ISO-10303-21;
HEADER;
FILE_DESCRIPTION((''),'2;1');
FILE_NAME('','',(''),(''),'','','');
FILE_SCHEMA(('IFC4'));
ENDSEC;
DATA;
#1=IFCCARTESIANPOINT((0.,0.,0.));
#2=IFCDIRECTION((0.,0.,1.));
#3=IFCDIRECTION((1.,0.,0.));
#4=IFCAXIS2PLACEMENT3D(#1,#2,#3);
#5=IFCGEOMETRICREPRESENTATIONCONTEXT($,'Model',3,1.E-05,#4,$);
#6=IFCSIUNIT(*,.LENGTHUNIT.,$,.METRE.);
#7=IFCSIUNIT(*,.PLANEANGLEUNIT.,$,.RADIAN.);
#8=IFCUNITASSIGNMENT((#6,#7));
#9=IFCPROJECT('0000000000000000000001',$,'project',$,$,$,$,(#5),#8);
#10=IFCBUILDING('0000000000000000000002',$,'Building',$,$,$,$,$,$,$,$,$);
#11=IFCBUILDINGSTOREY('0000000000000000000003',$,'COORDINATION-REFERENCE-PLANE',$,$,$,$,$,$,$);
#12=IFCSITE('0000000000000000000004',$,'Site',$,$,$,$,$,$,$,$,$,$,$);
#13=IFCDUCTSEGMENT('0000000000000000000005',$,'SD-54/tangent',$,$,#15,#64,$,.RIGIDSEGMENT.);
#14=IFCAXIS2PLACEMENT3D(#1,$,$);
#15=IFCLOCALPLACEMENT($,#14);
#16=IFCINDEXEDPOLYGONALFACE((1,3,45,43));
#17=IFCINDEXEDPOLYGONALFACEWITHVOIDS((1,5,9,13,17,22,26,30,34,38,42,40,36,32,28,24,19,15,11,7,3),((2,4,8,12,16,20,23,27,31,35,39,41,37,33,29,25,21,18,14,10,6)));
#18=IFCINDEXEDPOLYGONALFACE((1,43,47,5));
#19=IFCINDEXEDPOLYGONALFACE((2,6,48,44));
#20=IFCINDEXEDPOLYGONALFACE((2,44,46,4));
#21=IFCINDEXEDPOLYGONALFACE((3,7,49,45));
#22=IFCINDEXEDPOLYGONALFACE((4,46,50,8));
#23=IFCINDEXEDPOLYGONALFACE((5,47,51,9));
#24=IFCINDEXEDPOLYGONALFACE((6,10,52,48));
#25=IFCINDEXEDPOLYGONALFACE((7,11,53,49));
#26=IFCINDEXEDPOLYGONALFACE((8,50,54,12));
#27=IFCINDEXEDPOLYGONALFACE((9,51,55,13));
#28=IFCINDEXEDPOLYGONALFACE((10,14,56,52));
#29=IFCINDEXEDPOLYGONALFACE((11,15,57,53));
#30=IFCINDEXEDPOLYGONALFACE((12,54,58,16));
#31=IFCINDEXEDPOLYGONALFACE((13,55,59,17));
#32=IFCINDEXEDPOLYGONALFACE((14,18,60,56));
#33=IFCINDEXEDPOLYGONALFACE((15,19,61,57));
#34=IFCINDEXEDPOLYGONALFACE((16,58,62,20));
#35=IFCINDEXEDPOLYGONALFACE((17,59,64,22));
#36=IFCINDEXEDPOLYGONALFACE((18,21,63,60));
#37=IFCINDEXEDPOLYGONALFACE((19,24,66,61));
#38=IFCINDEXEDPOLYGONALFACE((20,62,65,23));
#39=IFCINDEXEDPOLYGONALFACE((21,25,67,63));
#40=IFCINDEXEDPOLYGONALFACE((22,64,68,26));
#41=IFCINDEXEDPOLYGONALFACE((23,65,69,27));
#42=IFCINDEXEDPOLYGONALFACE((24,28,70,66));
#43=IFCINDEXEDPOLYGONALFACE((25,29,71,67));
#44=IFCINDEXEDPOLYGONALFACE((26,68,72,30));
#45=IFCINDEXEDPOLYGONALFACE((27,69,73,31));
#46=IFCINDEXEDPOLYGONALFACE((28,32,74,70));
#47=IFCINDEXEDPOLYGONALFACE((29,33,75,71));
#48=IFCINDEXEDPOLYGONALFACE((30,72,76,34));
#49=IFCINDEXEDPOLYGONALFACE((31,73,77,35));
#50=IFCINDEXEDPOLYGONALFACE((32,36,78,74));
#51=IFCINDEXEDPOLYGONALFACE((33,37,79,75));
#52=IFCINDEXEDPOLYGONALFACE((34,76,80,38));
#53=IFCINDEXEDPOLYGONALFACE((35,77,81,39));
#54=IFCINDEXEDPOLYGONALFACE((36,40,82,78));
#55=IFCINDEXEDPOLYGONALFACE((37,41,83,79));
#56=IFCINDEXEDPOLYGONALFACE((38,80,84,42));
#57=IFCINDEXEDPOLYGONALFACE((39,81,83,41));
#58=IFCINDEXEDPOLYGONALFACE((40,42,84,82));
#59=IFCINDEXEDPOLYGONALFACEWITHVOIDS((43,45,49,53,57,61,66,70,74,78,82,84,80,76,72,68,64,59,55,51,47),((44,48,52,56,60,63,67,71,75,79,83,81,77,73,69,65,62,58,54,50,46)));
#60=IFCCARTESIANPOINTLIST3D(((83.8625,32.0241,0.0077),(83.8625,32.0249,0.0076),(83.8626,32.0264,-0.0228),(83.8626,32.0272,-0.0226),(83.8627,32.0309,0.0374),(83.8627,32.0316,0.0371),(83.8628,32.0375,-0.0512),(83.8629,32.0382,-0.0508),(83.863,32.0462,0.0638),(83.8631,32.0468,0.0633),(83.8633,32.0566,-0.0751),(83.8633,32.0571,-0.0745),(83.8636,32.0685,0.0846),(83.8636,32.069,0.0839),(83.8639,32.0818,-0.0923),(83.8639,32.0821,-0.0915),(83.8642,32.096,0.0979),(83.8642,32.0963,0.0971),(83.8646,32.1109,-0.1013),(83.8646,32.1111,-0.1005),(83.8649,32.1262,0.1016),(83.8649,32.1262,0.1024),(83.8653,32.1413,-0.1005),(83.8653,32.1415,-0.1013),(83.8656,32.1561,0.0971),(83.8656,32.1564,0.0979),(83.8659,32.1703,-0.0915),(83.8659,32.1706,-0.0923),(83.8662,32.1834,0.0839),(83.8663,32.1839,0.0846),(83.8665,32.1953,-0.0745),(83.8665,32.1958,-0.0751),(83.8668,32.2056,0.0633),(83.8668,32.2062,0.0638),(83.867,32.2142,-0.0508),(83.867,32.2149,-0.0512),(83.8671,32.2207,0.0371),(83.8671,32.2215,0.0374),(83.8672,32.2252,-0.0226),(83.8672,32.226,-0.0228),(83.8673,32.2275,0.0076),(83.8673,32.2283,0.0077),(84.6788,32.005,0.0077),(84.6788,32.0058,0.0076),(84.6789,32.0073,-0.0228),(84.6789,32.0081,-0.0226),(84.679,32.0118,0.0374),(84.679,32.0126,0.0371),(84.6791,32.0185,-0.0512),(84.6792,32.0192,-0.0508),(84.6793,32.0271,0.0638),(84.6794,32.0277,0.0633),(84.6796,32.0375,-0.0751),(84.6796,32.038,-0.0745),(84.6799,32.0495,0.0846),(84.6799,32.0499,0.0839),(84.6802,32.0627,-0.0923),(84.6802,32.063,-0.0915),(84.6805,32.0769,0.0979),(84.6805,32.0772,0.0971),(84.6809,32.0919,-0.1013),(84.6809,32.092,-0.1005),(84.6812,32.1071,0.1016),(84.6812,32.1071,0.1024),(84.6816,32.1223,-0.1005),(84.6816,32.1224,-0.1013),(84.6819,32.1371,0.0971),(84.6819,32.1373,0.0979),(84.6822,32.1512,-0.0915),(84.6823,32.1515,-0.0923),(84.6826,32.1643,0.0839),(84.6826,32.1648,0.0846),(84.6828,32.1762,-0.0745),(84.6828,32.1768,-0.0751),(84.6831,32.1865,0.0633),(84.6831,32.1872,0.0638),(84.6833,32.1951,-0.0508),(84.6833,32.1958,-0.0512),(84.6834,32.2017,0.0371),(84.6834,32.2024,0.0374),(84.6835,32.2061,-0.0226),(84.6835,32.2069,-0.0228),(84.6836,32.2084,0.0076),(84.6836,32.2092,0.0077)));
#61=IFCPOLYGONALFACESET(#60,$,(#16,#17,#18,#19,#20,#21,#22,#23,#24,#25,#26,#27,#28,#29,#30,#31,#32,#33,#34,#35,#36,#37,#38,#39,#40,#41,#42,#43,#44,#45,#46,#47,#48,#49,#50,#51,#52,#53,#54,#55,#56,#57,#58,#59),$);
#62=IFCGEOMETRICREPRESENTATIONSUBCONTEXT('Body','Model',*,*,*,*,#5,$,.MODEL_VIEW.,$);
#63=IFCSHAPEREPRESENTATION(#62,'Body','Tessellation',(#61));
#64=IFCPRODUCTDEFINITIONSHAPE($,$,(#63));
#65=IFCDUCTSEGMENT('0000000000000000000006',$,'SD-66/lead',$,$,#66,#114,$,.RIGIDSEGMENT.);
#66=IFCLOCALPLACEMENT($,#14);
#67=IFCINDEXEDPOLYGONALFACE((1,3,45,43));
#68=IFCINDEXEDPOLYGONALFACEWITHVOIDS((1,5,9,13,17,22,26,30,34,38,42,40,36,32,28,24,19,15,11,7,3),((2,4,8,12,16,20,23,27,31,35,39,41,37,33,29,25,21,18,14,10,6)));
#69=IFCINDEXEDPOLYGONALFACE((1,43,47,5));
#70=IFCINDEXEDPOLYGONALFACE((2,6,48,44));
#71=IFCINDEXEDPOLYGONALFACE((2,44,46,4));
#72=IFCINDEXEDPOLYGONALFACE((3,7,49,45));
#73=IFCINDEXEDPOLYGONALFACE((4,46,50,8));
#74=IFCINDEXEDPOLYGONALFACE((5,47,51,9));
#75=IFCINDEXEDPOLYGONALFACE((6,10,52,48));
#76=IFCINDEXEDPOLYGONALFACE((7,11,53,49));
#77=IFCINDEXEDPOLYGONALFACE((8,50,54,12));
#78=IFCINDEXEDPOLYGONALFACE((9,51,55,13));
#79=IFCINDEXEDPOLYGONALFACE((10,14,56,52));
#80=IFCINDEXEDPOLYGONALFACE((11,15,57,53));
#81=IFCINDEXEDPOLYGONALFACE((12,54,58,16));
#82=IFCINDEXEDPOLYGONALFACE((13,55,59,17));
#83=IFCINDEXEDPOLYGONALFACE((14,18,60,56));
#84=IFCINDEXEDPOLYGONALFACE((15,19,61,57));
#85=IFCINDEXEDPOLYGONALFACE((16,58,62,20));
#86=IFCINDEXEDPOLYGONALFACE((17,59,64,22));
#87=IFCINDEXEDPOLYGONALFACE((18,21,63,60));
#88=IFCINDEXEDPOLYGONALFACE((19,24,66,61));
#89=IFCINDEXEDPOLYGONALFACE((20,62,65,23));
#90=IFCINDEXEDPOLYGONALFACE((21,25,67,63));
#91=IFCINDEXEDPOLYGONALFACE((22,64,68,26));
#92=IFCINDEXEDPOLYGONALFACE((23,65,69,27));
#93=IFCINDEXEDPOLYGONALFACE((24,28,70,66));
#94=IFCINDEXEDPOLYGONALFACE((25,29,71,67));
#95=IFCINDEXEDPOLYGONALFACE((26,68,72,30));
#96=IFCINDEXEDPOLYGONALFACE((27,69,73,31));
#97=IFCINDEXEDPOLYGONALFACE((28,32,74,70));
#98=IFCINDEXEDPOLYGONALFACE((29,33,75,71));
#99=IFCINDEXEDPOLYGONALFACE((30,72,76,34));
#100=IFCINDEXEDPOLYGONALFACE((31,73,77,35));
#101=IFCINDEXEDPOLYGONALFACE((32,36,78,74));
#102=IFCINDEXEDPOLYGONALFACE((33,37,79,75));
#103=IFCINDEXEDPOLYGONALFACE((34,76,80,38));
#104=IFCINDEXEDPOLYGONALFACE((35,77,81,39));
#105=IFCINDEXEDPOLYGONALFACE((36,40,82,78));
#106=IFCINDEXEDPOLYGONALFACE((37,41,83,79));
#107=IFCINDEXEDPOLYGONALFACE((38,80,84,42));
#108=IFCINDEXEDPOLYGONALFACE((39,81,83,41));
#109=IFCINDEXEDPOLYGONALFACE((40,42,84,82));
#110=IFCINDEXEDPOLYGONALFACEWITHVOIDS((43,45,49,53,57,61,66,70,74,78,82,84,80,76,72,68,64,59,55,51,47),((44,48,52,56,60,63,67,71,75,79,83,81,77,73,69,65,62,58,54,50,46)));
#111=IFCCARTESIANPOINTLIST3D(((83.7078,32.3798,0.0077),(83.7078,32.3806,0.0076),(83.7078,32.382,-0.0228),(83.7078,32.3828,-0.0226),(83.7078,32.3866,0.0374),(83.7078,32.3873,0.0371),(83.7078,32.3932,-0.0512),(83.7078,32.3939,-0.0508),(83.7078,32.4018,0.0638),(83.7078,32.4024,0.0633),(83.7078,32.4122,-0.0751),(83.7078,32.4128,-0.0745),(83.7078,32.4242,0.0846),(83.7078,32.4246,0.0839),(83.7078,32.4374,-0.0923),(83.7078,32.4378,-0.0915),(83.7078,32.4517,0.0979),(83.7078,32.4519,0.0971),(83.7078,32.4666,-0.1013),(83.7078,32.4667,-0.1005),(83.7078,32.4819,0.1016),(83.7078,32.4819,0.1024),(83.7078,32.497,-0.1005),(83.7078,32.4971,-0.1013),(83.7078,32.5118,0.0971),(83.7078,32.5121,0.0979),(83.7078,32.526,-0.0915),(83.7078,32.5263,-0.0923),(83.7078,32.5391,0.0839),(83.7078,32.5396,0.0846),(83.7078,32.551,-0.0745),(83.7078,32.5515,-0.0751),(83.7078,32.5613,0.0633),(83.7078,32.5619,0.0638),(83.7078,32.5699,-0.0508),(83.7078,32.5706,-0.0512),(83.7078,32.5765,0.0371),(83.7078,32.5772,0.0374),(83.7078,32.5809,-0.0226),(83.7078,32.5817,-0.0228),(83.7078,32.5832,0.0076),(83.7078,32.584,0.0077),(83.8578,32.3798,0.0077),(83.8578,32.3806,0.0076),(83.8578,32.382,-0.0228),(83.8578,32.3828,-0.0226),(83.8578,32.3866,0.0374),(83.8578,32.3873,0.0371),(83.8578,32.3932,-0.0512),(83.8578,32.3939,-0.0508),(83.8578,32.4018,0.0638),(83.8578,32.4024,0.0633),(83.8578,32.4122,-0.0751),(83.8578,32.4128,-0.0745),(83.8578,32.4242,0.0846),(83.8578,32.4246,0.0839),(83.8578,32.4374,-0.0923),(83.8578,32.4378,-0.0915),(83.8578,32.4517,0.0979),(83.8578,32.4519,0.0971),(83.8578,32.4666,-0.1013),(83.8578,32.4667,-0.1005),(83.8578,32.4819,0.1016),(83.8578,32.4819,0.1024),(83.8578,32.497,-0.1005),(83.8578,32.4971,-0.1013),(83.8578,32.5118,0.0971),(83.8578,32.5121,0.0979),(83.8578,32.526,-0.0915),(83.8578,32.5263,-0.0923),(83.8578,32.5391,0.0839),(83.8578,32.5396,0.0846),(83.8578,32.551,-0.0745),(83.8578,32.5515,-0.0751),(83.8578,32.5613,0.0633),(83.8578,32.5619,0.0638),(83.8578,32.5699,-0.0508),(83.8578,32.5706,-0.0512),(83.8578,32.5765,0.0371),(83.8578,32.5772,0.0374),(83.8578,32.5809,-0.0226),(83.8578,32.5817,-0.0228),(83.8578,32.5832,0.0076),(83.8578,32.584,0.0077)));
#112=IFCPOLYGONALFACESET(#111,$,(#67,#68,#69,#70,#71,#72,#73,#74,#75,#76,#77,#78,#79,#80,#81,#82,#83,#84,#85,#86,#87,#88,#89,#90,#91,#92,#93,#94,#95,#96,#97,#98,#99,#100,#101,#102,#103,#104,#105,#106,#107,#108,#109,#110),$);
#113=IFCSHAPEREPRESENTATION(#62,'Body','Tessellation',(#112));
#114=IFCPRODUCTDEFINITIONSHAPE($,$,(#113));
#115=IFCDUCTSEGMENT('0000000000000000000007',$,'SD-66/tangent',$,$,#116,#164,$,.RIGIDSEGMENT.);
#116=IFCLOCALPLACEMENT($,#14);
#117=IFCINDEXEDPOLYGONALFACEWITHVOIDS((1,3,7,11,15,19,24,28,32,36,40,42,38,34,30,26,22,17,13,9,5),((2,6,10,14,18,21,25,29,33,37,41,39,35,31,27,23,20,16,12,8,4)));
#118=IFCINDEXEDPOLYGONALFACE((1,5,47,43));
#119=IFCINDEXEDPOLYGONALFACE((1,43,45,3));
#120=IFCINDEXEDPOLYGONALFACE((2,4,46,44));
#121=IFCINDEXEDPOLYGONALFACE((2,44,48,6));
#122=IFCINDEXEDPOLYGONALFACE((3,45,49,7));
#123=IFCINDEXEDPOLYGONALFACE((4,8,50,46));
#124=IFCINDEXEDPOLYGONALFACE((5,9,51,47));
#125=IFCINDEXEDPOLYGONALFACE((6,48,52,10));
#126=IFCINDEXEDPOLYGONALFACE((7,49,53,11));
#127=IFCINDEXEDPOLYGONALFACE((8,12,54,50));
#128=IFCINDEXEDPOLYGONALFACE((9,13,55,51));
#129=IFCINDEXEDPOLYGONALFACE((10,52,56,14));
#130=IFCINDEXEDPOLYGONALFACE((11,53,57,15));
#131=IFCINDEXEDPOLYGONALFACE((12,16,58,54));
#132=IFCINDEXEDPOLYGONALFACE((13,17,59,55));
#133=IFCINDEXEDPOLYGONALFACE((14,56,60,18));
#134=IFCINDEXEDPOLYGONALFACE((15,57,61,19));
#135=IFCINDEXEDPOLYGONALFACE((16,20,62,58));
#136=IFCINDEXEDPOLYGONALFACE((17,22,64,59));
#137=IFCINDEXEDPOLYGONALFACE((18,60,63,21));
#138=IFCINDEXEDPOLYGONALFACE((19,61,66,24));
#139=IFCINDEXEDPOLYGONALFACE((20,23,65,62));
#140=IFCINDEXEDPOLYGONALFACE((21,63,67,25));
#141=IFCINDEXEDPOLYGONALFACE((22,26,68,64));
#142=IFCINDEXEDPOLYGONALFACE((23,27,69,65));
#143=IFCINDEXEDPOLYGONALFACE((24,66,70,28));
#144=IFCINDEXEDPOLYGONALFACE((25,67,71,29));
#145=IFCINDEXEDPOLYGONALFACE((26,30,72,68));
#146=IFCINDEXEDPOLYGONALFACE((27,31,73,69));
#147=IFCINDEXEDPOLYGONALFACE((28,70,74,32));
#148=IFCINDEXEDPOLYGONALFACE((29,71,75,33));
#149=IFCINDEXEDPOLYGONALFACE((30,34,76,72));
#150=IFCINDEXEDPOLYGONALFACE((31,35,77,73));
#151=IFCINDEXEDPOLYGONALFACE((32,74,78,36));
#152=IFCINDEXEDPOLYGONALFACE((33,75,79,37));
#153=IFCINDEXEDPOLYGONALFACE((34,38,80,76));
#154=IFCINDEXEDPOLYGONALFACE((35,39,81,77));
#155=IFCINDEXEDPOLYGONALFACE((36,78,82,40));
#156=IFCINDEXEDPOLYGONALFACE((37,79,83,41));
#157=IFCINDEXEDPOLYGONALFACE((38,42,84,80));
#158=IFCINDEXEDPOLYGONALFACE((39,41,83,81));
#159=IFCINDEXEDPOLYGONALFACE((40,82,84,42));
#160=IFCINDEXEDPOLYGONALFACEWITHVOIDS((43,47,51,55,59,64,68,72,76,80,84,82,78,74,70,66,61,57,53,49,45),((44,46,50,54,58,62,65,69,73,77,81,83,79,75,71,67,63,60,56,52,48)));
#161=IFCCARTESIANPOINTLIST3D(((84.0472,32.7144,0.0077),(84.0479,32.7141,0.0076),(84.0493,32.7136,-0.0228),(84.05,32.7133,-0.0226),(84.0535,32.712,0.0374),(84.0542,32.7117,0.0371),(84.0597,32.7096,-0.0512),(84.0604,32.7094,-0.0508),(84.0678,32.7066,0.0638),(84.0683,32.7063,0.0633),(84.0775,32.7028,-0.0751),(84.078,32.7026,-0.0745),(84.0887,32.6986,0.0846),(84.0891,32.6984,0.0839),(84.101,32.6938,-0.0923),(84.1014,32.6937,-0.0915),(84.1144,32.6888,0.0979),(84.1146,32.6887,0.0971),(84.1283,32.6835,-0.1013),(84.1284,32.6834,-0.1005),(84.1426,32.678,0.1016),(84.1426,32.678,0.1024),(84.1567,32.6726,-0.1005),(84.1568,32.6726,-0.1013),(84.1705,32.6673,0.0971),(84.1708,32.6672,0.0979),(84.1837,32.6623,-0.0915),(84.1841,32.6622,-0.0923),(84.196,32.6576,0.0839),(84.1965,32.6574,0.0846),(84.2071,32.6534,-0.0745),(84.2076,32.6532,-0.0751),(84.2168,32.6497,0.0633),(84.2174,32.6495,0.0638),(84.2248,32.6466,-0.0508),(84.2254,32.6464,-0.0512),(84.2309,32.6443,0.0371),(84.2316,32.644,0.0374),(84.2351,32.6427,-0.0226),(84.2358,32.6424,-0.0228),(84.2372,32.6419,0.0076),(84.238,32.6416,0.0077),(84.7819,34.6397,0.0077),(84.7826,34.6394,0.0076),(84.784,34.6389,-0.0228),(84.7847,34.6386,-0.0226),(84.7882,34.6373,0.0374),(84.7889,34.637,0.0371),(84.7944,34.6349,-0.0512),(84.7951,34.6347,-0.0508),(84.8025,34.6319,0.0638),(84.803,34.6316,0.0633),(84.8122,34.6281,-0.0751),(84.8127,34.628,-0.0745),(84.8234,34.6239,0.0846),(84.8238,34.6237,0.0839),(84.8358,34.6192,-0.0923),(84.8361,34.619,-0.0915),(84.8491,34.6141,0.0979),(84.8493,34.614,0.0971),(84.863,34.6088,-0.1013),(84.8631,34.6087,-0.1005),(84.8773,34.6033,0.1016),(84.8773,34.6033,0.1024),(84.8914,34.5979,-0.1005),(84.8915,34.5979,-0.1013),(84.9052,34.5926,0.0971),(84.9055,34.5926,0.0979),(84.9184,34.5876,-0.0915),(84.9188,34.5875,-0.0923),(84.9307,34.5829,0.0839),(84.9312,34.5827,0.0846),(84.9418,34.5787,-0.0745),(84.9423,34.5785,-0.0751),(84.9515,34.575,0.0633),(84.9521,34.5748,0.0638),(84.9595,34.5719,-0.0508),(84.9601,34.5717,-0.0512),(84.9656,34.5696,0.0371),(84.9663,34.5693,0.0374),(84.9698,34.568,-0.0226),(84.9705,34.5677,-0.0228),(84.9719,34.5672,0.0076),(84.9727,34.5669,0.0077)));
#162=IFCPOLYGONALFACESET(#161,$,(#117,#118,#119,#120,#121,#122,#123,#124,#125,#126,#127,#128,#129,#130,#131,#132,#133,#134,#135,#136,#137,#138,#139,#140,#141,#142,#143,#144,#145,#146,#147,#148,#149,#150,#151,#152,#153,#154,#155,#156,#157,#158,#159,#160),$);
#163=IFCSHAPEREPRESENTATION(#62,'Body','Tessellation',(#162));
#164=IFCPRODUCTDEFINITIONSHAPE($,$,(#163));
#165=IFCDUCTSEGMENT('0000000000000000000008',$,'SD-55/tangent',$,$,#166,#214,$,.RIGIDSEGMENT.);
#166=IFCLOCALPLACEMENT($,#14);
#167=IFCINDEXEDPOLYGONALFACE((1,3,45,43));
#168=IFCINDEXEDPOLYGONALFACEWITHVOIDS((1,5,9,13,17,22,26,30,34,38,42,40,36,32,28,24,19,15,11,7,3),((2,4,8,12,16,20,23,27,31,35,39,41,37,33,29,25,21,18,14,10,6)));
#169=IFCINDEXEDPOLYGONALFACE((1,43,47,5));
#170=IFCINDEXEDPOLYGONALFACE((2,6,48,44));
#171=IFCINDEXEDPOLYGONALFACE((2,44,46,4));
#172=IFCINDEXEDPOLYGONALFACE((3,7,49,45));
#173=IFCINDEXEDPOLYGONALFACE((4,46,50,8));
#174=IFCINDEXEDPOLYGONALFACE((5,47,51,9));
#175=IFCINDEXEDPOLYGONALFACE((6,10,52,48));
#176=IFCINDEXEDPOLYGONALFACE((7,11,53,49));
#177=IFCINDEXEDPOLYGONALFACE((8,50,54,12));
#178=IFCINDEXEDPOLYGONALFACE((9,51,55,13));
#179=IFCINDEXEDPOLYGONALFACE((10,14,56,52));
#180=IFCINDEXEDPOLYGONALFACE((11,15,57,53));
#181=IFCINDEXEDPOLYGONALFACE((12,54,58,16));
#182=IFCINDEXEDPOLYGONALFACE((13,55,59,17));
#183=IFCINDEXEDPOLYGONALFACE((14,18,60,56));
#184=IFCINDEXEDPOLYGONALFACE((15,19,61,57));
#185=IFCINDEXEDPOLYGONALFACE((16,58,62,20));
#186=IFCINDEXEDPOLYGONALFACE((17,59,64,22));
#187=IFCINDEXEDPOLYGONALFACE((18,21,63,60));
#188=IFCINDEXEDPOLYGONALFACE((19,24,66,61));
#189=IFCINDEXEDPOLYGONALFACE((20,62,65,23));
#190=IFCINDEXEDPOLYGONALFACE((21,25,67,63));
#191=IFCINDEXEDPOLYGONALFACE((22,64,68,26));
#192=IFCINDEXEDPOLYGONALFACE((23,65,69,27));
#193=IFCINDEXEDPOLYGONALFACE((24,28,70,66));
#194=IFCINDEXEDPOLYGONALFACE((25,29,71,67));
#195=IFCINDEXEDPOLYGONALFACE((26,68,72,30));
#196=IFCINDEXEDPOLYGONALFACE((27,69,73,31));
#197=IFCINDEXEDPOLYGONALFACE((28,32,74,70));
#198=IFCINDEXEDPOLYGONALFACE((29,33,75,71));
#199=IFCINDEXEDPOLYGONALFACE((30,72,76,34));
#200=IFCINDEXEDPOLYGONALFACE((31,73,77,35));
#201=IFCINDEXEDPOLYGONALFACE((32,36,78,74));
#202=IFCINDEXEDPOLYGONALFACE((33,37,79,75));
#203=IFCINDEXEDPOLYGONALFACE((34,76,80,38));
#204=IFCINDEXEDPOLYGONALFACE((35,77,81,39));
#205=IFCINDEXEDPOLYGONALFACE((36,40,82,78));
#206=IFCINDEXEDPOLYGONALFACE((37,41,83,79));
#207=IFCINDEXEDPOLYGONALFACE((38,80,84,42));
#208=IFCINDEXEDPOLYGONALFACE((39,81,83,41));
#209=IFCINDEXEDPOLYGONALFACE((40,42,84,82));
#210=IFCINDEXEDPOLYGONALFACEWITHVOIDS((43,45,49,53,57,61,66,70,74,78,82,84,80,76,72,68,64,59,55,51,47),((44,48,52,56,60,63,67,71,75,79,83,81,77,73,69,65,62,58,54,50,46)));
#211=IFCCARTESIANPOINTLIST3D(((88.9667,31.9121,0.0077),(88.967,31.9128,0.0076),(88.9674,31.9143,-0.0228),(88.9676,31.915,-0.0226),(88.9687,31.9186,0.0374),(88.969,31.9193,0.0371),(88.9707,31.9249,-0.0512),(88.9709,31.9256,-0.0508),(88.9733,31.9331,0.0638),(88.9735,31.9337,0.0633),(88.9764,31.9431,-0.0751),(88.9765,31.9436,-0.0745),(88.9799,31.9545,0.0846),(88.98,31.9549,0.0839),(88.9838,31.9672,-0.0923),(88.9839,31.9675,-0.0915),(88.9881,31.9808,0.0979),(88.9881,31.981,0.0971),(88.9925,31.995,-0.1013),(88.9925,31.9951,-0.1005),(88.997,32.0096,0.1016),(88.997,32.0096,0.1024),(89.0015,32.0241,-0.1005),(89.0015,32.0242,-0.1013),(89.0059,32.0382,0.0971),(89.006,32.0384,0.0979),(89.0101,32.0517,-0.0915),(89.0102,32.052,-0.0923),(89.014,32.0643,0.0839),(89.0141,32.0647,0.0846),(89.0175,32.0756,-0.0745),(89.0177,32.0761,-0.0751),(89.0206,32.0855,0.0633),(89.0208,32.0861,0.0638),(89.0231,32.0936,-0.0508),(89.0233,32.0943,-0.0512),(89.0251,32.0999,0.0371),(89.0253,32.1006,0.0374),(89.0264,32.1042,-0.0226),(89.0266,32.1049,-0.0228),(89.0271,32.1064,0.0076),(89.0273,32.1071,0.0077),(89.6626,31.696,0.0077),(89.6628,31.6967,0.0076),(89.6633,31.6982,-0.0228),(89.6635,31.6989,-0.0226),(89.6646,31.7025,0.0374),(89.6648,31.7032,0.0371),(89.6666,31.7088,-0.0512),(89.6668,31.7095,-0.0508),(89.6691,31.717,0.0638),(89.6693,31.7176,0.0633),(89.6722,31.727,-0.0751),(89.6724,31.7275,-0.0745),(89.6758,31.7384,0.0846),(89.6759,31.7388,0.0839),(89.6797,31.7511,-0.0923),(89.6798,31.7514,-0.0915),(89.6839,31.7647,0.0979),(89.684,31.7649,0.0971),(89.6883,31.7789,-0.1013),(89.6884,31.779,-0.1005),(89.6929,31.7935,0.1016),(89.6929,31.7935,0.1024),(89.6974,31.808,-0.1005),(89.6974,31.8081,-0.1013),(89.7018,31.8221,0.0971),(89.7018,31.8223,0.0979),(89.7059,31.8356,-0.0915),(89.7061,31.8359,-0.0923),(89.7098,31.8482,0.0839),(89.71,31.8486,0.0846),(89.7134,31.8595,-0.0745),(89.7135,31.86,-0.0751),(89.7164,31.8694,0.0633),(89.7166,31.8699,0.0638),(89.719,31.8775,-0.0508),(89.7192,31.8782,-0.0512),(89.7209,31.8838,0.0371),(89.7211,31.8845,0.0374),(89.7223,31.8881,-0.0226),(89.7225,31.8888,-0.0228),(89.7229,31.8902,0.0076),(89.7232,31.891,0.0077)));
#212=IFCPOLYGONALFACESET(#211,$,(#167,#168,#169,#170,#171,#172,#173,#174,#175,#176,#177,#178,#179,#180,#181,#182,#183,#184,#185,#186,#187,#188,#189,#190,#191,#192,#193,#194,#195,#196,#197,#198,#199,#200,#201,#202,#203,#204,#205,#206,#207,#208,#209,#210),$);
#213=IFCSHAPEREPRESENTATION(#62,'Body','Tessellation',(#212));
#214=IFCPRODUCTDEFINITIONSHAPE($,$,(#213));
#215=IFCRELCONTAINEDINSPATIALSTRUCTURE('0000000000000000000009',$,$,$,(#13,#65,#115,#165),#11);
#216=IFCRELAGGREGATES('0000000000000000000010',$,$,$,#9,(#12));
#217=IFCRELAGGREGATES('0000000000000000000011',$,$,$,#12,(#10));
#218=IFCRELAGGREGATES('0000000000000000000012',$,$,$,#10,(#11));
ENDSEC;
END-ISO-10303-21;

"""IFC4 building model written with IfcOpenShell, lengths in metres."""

from ifc_helpers import new_model, si_unit, frame, origin_with_axes, place, context, subcontext, project, spatial, hollow_circle, extrude, element, save


model = new_model("IFC4")

# Units and contexts
model_context = context("Model", 3, precision=1e-05, world=origin_with_axes())
body_context_1 = subcontext(model_context, "Body", "Model", "MODEL_VIEW")
ifc_project = project(units=[si_unit("LENGTHUNIT", "METRE"), si_unit("PLANEANGLEUNIT", "RADIAN")], contexts=[model_context])

# Site, building, storey
site = spatial("IfcSite", under=ifc_project, Name="Site")
building = spatial("IfcBuilding", under=site, Name="Building")
storey = spatial("IfcBuildingStorey", under=building, Name="COORDINATION-REFERENCE-PLANE")

# Duct segment
duct_segment_1_placement = place(None, frame((83.8649, 32.1262, 0.0), z_axis=(0.999727, -0.023361, 0.0), x_axis=(0.0, 0.0, 1.0)))
element("IfcDuctSegment", 1, at=duct_segment_1_placement, inside=storey, Name="SD-54/tangent", PredefinedType="RIGIDSEGMENT", context=body_context_1, shape_type="SweptSolid", body=[
    extrude(hollow_circle(Radius=0.1024, WallThickness=0.0008), origin_with_axes(), (0.0, 0.0, 1.0), 0.8165),
])

# Duct segment
duct_segment_2_placement = place(None, frame((83.7078, 32.4819, 0.0), z_axis=(1.0, 0.0, 0.0), x_axis=(0.0, 0.0, 1.0)))
element("IfcDuctSegment", 2, at=duct_segment_2_placement, inside=storey, Name="SD-66/lead", PredefinedType="RIGIDSEGMENT", context=body_context_1, shape_type="SweptSolid", body=[
    extrude(hollow_circle(Radius=0.1024, WallThickness=0.0008), origin_with_axes(), (0.0, 0.0, 1.0), 0.15),
])

# Duct segment
duct_segment_3_placement = place(None, frame((84.1426, 32.678, 0.0), z_axis=(0.356527, 0.934285, 0.0), x_axis=(0.0, 0.0, 1.0)))
element("IfcDuctSegment", 3, at=duct_segment_3_placement, inside=storey, Name="SD-66/tangent", PredefinedType="RIGIDSEGMENT", context=body_context_1, shape_type="SweptSolid", body=[
    extrude(hollow_circle(Radius=0.1024, WallThickness=0.0008), origin_with_axes(), (0.0, 0.0, 1.0), 2.0607),
])

# Duct segment
duct_segment_4_placement = place(None, frame((89.6929, 31.7935, 0.0), z_axis=(-0.955005, 0.296589, 0.0), x_axis=(0.0, 0.0, 1.0)))
element("IfcDuctSegment", 4, at=duct_segment_4_placement, inside=storey, Name="SD-55/tangent", PredefinedType="RIGIDSEGMENT", context=body_context_1, shape_type="SweptSolid", body=[
    extrude(hollow_circle(Radius=0.1024, WallThickness=0.0008), origin_with_axes(), (0.0, 0.0, 1.0), 0.7286),
])

save(model, "model.ifc")
